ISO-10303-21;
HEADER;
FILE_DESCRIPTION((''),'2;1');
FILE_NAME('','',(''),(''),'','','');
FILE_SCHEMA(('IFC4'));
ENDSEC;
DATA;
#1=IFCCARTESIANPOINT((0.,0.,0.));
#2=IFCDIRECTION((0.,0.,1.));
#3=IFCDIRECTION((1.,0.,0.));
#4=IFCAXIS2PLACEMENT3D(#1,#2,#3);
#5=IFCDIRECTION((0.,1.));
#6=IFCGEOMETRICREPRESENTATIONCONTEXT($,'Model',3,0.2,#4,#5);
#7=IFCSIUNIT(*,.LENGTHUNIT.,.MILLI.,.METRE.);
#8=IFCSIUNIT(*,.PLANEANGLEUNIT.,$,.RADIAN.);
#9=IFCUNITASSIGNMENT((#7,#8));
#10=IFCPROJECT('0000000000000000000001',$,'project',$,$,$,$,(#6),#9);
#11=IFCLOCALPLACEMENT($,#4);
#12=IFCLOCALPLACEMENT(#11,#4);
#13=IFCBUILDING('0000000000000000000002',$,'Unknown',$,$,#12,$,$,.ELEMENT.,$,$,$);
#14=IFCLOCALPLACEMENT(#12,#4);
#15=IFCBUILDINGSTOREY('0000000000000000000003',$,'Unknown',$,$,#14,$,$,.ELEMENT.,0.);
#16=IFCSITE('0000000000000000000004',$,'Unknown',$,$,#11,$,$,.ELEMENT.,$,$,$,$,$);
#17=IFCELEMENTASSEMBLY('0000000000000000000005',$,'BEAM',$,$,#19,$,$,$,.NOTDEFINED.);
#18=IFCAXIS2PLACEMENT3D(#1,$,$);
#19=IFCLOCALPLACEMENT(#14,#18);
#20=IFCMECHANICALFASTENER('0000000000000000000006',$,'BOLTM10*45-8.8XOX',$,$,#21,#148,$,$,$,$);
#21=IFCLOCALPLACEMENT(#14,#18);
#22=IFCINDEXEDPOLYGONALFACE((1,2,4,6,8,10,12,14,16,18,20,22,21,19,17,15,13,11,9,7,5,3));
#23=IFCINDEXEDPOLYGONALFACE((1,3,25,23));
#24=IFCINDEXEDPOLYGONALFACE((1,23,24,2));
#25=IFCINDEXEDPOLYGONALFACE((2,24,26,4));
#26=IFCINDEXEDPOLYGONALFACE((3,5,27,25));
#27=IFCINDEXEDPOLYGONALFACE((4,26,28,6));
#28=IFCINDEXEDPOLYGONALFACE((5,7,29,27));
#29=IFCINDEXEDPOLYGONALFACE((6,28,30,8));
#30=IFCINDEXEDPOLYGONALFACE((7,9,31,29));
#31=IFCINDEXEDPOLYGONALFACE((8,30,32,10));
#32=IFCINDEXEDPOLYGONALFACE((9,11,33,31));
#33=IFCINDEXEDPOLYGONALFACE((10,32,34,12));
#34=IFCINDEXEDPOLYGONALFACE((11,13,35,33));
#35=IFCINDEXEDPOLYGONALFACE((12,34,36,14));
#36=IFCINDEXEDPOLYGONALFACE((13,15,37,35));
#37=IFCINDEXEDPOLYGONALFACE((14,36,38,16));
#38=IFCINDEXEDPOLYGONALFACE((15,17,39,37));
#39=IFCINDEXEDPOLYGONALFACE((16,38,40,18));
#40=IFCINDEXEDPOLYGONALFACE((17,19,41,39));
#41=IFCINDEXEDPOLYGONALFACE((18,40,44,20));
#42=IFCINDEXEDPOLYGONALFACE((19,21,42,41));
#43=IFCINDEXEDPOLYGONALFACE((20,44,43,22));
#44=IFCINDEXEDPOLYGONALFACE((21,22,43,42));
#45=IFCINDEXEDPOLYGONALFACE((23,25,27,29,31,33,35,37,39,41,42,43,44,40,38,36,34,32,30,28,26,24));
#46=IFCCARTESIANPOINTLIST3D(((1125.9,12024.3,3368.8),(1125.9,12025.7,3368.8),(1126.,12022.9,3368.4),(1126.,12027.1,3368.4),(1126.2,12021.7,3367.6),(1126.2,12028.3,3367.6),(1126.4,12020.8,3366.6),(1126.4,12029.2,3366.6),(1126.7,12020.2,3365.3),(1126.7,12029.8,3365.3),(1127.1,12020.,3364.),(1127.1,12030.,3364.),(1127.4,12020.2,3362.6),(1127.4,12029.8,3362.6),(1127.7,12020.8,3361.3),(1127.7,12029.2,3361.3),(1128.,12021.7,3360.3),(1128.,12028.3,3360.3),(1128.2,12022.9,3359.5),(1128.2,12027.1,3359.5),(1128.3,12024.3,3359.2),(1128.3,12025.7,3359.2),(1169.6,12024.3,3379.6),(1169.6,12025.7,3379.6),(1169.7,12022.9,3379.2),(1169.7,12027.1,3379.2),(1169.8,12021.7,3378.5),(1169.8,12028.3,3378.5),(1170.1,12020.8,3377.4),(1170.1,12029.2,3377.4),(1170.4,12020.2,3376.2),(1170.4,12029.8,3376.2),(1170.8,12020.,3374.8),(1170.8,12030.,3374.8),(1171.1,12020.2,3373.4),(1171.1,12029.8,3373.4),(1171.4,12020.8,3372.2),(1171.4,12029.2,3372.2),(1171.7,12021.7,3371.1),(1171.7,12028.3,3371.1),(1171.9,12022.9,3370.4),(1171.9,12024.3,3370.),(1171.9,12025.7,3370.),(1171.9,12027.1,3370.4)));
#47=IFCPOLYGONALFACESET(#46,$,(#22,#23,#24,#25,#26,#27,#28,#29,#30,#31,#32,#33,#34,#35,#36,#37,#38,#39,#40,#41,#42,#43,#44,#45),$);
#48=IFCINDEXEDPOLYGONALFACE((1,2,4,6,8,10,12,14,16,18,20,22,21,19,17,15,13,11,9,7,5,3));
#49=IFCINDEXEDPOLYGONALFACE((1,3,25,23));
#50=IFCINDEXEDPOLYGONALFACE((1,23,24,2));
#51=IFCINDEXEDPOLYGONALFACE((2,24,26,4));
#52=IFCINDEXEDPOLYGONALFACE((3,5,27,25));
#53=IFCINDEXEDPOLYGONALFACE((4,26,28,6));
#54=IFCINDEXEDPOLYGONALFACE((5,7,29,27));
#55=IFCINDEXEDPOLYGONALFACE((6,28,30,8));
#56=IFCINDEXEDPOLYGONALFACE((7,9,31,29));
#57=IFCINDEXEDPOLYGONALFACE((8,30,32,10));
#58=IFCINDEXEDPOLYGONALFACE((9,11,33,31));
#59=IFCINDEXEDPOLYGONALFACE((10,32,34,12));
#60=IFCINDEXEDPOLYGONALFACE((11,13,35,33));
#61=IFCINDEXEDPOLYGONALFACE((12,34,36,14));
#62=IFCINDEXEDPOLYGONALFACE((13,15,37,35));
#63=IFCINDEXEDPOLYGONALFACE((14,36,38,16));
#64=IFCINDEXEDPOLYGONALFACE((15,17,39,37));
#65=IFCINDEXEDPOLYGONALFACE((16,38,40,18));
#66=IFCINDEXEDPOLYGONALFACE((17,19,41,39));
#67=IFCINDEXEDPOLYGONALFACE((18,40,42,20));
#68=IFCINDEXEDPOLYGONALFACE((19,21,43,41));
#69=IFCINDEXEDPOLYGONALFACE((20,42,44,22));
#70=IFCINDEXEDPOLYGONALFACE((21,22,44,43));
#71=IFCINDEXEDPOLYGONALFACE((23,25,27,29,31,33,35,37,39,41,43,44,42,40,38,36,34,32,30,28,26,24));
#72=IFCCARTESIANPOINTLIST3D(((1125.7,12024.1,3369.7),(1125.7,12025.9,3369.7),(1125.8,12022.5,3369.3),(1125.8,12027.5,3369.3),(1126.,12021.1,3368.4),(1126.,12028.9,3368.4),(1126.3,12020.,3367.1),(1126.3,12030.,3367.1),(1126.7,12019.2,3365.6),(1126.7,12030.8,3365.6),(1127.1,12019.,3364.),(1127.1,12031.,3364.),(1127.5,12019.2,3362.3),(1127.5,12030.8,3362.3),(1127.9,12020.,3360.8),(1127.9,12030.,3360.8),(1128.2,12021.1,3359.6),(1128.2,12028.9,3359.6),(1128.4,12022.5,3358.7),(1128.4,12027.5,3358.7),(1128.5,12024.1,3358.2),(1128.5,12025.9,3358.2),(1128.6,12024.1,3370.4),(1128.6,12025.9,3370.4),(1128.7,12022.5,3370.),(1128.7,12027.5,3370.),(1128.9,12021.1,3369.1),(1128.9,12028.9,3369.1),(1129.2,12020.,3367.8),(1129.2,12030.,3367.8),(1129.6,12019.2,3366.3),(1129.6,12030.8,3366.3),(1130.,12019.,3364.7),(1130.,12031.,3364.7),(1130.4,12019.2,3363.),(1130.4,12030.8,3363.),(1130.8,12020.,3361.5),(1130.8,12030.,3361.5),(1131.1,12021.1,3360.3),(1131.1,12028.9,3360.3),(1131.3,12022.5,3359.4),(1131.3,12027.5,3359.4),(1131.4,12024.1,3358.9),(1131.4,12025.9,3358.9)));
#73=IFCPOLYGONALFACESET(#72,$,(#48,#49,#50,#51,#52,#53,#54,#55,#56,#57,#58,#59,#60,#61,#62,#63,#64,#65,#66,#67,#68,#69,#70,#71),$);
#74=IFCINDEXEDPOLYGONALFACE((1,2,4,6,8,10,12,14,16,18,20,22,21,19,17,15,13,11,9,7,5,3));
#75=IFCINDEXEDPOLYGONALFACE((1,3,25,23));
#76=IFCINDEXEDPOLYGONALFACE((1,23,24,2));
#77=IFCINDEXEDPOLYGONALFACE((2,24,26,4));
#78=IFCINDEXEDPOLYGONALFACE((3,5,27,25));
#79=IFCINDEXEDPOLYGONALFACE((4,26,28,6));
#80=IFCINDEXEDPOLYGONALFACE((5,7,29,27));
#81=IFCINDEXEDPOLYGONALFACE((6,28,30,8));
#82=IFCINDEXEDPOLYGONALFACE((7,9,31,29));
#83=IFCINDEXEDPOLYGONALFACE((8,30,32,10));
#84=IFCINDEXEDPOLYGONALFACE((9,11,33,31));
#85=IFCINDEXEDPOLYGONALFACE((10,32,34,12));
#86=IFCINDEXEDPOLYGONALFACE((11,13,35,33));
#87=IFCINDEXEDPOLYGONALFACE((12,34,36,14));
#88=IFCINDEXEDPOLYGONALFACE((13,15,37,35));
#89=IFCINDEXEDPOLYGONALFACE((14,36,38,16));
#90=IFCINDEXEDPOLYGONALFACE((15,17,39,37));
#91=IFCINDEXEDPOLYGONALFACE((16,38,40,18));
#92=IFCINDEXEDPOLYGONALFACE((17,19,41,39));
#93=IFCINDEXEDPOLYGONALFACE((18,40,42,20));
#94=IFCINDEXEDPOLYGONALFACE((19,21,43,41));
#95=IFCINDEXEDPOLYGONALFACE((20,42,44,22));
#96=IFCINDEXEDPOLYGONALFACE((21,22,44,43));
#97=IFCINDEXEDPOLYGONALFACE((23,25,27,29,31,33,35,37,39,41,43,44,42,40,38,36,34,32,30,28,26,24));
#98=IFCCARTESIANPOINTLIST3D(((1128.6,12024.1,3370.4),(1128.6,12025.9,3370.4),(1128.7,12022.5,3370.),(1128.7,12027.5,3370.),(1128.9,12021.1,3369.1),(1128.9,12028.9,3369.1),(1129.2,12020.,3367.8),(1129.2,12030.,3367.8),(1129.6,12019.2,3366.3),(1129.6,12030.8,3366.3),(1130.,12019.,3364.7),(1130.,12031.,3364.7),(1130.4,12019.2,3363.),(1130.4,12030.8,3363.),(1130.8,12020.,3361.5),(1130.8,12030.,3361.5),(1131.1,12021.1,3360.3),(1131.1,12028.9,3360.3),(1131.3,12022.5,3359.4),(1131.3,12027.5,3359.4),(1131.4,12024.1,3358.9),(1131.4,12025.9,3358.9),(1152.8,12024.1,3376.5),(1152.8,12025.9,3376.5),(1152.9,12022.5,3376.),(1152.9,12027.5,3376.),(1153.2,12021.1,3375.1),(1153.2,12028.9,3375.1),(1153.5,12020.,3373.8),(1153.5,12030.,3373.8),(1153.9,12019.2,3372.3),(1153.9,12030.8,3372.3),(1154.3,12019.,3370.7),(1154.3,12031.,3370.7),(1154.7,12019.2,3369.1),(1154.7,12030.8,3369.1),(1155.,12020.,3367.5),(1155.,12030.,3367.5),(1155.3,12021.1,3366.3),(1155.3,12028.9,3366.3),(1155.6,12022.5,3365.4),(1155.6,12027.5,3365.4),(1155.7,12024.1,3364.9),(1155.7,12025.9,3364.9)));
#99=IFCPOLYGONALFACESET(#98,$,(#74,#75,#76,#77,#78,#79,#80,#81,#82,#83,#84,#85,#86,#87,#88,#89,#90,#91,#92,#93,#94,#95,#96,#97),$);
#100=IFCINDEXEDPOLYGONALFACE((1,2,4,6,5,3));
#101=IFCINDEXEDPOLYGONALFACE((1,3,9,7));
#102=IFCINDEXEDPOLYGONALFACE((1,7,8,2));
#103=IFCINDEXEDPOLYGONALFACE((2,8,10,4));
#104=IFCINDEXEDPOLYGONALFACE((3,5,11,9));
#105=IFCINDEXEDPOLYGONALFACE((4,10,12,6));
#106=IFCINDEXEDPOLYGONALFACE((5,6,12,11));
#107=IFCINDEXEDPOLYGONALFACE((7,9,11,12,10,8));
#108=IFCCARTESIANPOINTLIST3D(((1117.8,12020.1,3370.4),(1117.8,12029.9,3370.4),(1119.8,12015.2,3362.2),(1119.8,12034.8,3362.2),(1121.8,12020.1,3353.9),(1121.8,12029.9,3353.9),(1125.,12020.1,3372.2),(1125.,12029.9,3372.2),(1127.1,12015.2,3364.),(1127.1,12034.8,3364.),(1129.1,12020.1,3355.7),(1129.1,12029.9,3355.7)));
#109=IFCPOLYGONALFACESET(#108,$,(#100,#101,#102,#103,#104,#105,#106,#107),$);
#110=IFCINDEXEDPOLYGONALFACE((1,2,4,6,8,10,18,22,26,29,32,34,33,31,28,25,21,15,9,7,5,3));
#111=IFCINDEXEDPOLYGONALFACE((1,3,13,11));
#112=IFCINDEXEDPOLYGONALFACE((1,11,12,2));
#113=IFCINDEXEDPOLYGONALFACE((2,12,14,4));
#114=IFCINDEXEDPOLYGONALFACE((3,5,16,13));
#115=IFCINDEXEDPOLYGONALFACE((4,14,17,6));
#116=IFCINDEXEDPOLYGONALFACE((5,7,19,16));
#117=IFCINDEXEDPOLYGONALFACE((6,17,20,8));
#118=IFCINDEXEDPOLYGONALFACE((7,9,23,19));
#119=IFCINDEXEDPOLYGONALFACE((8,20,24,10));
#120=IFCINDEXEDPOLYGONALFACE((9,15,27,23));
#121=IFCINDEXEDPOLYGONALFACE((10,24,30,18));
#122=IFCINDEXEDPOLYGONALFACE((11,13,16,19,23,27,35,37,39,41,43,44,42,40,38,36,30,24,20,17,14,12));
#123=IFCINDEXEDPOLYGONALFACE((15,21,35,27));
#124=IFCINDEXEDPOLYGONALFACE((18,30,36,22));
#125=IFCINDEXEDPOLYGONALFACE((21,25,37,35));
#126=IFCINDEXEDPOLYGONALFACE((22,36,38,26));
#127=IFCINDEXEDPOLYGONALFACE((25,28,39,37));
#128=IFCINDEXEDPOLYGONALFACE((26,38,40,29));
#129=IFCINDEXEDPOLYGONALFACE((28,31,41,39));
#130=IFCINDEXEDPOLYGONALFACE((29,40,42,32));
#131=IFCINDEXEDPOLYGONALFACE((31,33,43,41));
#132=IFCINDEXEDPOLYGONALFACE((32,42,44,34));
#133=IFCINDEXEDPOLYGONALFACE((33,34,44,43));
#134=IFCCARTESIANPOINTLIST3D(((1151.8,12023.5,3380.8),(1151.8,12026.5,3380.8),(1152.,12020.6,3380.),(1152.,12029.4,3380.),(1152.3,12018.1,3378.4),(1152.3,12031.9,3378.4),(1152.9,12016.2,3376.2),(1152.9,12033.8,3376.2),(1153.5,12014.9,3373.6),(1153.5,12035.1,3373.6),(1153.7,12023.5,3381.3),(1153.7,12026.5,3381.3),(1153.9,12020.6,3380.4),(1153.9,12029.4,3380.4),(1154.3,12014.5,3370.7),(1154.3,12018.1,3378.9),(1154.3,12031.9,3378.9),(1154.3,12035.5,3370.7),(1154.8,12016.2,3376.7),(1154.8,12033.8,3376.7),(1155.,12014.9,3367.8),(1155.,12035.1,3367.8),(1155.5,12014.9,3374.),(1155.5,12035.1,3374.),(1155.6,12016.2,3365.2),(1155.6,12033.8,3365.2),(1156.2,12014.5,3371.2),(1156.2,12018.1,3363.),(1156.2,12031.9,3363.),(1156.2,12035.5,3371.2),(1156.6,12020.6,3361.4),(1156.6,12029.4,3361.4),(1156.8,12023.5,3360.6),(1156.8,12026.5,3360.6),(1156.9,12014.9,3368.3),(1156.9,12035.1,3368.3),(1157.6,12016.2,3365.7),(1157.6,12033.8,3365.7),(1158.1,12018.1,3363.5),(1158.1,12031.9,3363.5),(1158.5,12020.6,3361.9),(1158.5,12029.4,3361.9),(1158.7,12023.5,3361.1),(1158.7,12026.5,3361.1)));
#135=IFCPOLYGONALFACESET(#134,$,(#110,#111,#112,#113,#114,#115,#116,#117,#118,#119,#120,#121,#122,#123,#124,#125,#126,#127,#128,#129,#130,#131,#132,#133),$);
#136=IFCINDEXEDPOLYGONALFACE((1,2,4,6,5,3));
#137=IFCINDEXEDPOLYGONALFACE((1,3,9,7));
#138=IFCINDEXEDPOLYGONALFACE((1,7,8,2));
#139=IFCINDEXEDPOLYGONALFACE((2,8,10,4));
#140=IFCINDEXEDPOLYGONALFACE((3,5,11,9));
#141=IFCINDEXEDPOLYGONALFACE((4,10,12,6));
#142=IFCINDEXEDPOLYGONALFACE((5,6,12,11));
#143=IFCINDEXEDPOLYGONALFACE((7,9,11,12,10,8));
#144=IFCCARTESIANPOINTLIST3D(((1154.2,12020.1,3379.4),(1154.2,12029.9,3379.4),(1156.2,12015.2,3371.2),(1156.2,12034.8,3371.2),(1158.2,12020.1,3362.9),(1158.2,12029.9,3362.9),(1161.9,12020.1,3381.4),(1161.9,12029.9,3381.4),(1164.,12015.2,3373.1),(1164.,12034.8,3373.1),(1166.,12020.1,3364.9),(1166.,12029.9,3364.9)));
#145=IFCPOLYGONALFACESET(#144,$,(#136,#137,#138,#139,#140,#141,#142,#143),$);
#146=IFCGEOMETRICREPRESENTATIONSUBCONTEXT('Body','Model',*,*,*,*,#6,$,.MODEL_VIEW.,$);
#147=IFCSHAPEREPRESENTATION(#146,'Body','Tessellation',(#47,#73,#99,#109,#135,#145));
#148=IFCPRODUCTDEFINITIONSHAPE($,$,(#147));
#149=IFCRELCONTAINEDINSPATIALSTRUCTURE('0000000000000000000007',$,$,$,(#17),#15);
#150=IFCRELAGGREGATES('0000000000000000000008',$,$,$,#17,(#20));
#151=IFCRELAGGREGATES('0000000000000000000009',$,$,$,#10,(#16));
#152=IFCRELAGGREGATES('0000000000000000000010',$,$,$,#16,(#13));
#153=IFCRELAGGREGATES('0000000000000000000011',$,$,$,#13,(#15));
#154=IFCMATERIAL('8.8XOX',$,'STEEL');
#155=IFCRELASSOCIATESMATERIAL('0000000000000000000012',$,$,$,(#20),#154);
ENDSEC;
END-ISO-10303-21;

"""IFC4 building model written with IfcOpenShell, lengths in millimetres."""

from ifc_helpers import new_model, si_unit, direction, frame, origin_with_axes, place, context, subcontext, project, spatial, line, arc, indexed_curve, outline, extrude, source, transform, mapped, material, element, aggregate, save


model = new_model("IFC4")

# Units and contexts
model_context = context("Model", 3, precision=0.2, world=origin_with_axes(), true_north=direction((0.0, 1.0)))
body_context = subcontext(model_context, "Body", "Model", "MODEL_VIEW")
ifc_project = project(units=[si_unit("LENGTHUNIT", "METRE", prefix="MILLI"), si_unit("PLANEANGLEUNIT", "RADIAN")], contexts=[model_context])

# Site, building, storey
site_placement = place(None, origin_with_axes())
site = spatial("IfcSite", under=ifc_project, at=site_placement, Name="Unknown", CompositionType="ELEMENT")
building_placement = place(site_placement, origin_with_axes())
building = spatial("IfcBuilding", under=site, at=building_placement, Name="Unknown", CompositionType="ELEMENT")
storey_placement = place(building_placement, origin_with_axes())
storey = spatial("IfcBuildingStorey", under=building, at=storey_placement, Name="Unknown", CompositionType="ELEMENT", Elevation=0.0)

# Shared definitions
ifc_material_1 = material(Name="8.8XOX", Category="STEEL")

# Element assembly, mechanical fastener
assembly_1_placement = place(storey_placement, frame((1140.9, 12000.0, 3372.5), z_axis=(0.970613, 0.0, 0.240648), x_axis=(0.0, 1.0, 0.0)))
assembly_1 = element("IfcElementAssembly", 1, at=assembly_1_placement, inside=storey, Name="BEAM", PredefinedType="NOTDEFINED")
shared_shape_1 = source(origin_with_axes(), body_context, "Body", "SweptSolid", [
    extrude(outline(indexed_curve([(5.0, 0.0), (0.0, 5.0), (-5.0, 0.0), (0.0, -5.0)], segments=[arc(1, 2, 3), arc(3, 4, 1)])), frame((0.0, 0.0, 3.8), z_axis=(0.0, 0.0, -1.0), x_axis=(0.0, 1.0, 0.0)), (0.0, 0.0, 1.0), 45.0),
    extrude(outline(indexed_curve([(6.0, 0.0), (0.0, 6.0), (-6.0, 0.0), (0.0, -6.0)], segments=[arc(1, 2, 3), arc(3, 4, 1)])), frame((0.0, 0.0, 3.8), z_axis=(0.0, 0.0, -1.0), x_axis=(0.0, 1.0, 0.0)), (0.0, 0.0, 1.0), 3.0),
    extrude(outline(indexed_curve([(6.0, 0.0), (0.0, 6.0), (-6.0, 0.0), (0.0, -6.0)], segments=[arc(1, 2, 3), arc(3, 4, 1)])), frame((0.0, 0.0, 0.8), z_axis=(0.0, 0.0, -1.0), x_axis=(0.0, 1.0, 0.0)), (0.0, 0.0, 1.0), 25.0),
    extrude(outline(indexed_curve([(9.8, 0.0), (4.9, 8.5), (-4.9, 8.5), (-9.8, 0.0), (-4.9, -8.5), (4.9, -8.5)], segments=[line(1, 2, 3, 4, 5, 6, 1)])), frame((0.0, 0.0, 11.2), z_axis=(0.0, 0.0, -1.0), x_axis=(0.0, 1.0, 0.0)), (0.0, 0.0, 1.0), 7.5),
    extrude(outline(indexed_curve([(10.5, 0.0), (0.0, 10.5), (-10.5, 0.0), (0.0, -10.5)], segments=[arc(1, 2, 3), arc(3, 4, 1)])), frame((0.0, 0.0, -24.2), z_axis=(0.0, 0.0, -1.0), x_axis=(0.0, 1.0, 0.0)), (0.0, 0.0, 1.0), 2.0),
    extrude(outline(indexed_curve([(9.8, 0.0), (4.9, 8.5), (-4.9, 8.5), (-9.8, 0.0), (-4.9, -8.5), (4.9, -8.5)], segments=[line(1, 2, 3, 4, 5, 6, 1)])), frame((0.0, 0.0, -26.2), z_axis=(0.0, 0.0, -1.0), x_axis=(0.0, 1.0, 0.0)), (0.0, 0.0, 1.0), 8.0),
])
mechanical_fastener_1_placement = place(assembly_1_placement, frame((25.0, -5.0, -11.8), z_axis=(0.0, 0.0, -1.0), x_axis=(0.0, 1.0, 0.0)))
mechanical_fastener_1 = element("IfcMechanicalFastener", 2, at=mechanical_fastener_1_placement, material=ifc_material_1, Name="BOLTM10*45-8.8XOX", context=body_context, shape_type="MappedRepresentation", body=[
    mapped(shared_shape_1, transform((0.0, 0.0, 0.0))),
])
aggregate(assembly_1, [mechanical_fastener_1])

save(model, "model.ifc")
